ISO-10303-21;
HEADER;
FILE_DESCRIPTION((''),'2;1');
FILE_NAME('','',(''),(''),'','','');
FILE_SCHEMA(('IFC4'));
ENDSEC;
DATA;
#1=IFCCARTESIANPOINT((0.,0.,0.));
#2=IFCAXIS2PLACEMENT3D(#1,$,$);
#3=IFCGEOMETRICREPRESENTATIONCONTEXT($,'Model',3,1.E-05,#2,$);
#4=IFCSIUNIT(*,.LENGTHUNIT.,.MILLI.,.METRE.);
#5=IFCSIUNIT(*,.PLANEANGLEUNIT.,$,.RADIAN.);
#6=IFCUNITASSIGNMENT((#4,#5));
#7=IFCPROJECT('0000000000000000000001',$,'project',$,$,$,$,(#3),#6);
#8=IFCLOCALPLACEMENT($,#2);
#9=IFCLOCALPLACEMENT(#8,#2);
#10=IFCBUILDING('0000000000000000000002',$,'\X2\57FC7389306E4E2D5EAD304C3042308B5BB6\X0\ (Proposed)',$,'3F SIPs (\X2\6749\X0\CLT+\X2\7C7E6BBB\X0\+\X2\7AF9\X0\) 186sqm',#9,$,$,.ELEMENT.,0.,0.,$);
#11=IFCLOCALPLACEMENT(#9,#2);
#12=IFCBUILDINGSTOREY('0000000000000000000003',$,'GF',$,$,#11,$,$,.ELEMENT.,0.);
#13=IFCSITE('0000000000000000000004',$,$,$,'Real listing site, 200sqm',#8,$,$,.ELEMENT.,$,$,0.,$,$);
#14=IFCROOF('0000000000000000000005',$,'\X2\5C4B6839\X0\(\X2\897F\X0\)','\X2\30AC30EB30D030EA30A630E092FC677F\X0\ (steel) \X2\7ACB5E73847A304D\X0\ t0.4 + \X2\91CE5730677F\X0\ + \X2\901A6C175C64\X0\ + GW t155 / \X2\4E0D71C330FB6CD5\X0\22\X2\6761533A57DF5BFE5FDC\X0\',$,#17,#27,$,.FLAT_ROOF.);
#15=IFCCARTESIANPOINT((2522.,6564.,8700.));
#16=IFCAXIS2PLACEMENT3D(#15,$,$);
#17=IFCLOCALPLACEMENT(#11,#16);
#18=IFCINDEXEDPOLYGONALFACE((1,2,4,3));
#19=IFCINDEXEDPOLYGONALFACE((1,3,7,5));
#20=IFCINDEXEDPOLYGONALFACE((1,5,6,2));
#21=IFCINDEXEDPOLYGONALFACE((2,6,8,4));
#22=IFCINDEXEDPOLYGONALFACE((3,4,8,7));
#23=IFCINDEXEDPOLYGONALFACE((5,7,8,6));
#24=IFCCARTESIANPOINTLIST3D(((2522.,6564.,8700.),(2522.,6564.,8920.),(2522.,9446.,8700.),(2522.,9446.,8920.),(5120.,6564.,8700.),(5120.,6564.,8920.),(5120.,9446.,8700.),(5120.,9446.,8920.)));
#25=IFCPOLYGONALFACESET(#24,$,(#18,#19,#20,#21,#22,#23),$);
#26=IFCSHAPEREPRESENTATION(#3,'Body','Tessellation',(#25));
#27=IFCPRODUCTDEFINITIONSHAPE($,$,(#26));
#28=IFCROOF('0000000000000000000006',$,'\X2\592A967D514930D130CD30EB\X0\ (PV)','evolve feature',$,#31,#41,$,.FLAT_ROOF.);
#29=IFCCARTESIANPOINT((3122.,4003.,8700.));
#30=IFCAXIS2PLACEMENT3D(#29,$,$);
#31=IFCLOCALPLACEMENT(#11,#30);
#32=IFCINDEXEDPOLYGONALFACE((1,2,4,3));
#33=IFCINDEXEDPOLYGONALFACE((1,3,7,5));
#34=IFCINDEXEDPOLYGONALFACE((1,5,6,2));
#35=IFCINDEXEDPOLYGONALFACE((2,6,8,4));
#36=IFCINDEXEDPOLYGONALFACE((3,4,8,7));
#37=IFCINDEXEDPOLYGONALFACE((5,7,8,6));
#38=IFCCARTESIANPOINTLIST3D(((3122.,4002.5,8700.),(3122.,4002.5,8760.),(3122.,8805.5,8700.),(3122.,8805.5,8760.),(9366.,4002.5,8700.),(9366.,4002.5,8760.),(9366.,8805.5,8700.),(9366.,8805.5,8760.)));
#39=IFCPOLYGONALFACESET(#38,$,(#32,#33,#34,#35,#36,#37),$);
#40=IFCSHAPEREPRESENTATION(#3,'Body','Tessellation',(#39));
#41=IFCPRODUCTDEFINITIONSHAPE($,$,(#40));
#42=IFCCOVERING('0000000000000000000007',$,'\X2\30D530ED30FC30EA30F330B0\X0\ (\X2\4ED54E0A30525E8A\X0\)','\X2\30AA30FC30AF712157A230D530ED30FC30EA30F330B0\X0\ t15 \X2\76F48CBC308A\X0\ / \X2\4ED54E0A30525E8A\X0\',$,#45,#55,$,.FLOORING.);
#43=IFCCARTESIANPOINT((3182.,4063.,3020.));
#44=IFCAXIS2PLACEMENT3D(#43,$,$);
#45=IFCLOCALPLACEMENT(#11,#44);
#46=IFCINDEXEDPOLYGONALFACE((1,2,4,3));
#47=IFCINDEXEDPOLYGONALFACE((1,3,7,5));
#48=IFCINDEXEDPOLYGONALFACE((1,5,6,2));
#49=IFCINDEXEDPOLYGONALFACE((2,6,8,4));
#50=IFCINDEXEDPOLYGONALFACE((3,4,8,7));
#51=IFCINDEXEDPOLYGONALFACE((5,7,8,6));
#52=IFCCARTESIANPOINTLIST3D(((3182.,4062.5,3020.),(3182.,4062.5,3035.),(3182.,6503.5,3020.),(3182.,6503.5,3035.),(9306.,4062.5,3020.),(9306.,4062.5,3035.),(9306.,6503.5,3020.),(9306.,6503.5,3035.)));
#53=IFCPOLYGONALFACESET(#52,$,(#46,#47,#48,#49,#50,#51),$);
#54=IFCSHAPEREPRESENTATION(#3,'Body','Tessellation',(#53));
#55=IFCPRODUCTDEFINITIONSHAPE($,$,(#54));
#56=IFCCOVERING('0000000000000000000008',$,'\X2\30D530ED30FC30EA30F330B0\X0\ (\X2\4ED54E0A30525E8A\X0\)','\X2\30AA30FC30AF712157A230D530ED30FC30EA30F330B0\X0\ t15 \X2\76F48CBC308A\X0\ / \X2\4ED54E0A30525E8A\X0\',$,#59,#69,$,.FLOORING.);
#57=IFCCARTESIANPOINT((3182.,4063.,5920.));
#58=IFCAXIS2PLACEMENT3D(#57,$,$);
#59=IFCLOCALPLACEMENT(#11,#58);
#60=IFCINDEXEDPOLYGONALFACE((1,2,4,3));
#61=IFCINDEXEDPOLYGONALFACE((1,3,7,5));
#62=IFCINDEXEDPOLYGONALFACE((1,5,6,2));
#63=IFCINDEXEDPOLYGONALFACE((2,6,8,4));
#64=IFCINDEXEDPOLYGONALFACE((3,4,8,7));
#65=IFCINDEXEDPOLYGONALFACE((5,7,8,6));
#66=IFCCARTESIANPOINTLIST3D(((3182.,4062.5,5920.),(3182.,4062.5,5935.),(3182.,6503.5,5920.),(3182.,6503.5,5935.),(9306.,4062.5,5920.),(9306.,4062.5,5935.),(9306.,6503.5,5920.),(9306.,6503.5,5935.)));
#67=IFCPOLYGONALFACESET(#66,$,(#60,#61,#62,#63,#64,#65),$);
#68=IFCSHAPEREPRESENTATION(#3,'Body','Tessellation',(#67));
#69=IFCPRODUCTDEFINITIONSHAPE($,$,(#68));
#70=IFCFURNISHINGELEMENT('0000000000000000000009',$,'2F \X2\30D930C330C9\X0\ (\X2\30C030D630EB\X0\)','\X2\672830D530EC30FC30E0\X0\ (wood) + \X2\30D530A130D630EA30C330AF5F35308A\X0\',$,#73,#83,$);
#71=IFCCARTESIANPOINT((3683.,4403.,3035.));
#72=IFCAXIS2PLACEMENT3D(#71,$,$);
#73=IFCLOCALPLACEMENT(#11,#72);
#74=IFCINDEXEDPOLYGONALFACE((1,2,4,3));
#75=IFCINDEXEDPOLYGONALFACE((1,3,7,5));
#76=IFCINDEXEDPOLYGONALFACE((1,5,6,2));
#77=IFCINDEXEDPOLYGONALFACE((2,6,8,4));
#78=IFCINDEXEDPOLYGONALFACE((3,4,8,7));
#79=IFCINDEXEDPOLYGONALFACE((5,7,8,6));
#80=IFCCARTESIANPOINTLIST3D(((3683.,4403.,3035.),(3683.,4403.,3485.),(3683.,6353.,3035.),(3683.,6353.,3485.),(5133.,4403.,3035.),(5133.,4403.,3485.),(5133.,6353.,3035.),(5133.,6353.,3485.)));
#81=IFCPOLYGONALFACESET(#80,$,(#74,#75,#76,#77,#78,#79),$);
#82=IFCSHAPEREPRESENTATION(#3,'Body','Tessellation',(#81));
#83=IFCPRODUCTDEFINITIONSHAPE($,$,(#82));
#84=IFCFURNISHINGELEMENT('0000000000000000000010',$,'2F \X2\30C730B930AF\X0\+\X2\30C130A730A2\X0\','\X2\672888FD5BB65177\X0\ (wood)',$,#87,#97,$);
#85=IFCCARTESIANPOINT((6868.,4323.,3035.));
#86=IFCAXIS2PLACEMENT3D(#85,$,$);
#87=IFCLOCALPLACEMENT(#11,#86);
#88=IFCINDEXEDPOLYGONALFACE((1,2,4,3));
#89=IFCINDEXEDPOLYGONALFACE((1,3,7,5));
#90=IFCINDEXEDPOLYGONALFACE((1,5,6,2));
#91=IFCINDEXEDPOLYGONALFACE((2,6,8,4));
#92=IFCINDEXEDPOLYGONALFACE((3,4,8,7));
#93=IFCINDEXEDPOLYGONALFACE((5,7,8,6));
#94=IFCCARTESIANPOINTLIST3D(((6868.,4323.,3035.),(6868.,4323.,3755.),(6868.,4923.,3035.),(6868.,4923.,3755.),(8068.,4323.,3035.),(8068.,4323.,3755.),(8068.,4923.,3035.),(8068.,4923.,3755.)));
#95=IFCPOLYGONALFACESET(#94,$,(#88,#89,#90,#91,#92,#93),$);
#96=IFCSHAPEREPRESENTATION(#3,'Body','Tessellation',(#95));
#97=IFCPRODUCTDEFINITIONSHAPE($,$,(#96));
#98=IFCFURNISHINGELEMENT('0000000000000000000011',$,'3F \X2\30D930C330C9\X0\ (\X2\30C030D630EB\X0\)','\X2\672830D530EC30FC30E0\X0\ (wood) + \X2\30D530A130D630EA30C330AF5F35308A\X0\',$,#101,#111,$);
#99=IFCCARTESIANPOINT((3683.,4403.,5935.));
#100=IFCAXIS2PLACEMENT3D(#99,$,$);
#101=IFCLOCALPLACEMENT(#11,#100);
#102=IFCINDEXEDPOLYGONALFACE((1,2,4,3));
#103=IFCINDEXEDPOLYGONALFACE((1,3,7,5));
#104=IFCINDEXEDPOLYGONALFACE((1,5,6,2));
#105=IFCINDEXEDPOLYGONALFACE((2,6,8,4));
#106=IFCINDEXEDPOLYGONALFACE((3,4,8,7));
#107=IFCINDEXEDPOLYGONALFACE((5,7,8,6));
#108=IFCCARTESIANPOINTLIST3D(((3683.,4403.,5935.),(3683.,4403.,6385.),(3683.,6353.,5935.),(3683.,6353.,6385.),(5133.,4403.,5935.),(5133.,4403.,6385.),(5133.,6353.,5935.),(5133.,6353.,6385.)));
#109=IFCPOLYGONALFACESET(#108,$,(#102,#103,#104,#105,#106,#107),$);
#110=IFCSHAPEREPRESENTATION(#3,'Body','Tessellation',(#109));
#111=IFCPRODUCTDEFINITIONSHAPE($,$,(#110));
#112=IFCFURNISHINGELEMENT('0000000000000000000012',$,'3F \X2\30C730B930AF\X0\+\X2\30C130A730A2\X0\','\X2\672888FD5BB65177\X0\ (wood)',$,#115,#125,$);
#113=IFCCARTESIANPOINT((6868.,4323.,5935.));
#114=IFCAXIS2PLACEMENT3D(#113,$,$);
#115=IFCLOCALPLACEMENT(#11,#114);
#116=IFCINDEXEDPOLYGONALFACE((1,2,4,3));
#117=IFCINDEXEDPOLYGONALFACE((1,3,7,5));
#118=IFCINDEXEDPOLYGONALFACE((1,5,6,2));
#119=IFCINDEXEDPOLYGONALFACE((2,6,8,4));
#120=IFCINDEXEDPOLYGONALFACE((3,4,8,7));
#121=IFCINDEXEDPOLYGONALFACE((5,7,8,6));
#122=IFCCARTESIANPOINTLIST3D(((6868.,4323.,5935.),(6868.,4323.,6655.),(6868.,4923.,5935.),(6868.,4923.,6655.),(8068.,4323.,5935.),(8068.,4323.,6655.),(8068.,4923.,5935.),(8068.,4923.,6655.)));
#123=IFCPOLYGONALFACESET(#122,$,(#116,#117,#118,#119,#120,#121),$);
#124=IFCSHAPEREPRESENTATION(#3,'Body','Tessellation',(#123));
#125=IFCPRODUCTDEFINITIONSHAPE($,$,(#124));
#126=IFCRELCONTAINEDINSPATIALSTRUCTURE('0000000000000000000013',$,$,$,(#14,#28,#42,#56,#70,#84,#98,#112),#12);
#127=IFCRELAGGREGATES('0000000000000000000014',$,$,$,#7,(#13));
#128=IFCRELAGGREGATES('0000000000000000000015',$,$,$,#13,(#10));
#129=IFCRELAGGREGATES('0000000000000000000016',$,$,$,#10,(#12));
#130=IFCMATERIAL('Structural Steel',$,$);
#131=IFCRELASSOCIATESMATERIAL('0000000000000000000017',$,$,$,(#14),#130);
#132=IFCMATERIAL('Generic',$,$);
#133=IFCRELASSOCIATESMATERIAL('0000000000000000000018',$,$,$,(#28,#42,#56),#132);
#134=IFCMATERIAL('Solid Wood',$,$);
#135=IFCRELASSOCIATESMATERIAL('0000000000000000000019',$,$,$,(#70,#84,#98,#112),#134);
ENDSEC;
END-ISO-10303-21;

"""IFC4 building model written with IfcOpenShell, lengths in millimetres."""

from ifc_helpers import new_model, si_unit, frame, frame_2d, origin, place, context, project, spatial, rectangle, extrude, material, element, save


model = new_model("IFC4")

# Units and contexts
model_context = context("Model", 3, precision=1e-05, world=origin())
ifc_project = project(units=[si_unit("LENGTHUNIT", "METRE", prefix="MILLI"), si_unit("PLANEANGLEUNIT", "RADIAN")], contexts=[model_context])

# Site, building, storey
site_placement = place(None, origin())
site = spatial("IfcSite", under=ifc_project, at=site_placement, ObjectType="Real listing site, 200sqm", CompositionType="ELEMENT", RefElevation=0.0)
building_placement = place(site_placement, origin())
building = spatial("IfcBuilding", under=site, at=building_placement, Name="埼玉の中庭がある家 (Proposed)", ObjectType="3F SIPs (杉CLT+籾殻+竹) 186sqm", CompositionType="ELEMENT", ElevationOfRefHeight=0.0, ElevationOfTerrain=0.0)
storey_placement = place(building_placement, origin())
storey = spatial("IfcBuildingStorey", under=building, at=storey_placement, Name="GF", CompositionType="ELEMENT", Elevation=0.0)

# Shared definitions
ifc_material_1 = material(Name="Solid Wood")

# Roofs
ifc_material_2 = material(Name="Structural Steel")
roof_1_placement = place(storey_placement, frame((2522.0, 6564.0, 8700.0)))
element("IfcRoof", 1, at=roof_1_placement, inside=storey, material=ifc_material_2, Name="屋根(西)", Description="ガルバリウム鋼板 (steel) 立平葺き t0.4 + 野地板 + 通気層 + GW t155 / 不燃・法22条区域対応", PredefinedType="FLAT_ROOF", context=model_context, shape_type="SweptSolid", body=[
    extrude(rectangle(XDim=2598.0, YDim=2882.0, at=frame_2d((1299.0, 1441.0))), frame((2522.0, 6564.0, 8700.0)), (0.0, 0.0, 1.0), 220.0),
])
ifc_material_3 = material(Name="Generic")
roof_2_placement = place(storey_placement, frame((3122.0, 4003.0, 8700.0)))
element("IfcRoof", 2, at=roof_2_placement, inside=storey, material=ifc_material_3, Name="太陽光パネル (PV)", Description="evolve feature", PredefinedType="FLAT_ROOF", context=model_context, shape_type="SweptSolid", body=[
    extrude(rectangle(XDim=6244.0, YDim=4803.0, at=frame_2d((3122.0, 2401.0))), frame((3122.0, 4003.0, 8700.0)), (0.0, 0.0, 1.0), 60.0),
])

# Coverings
covering_1_placement = place(storey_placement, frame((3182.0, 4063.0, 3020.0)))
element("IfcCovering", 3, at=covering_1_placement, inside=storey, material=ifc_material_3, Name="フローリング (仕上げ床)", Description="オーク無垢フローリング t15 直貼り / 仕上げ床", PredefinedType="FLOORING", context=model_context, shape_type="SweptSolid", body=[
    extrude(rectangle(XDim=6124.0, YDim=2441.0, at=frame_2d((3062.0, 1220.0))), frame((3182.0, 4063.0, 3020.0)), (0.0, 0.0, 1.0), 15.0),
])
covering_2_placement = place(storey_placement, frame((3182.0, 4063.0, 5920.0)))
element("IfcCovering", 4, at=covering_2_placement, inside=storey, material=ifc_material_3, Name="フローリング (仕上げ床)", Description="オーク無垢フローリング t15 直貼り / 仕上げ床", PredefinedType="FLOORING", context=model_context, shape_type="SweptSolid", body=[
    extrude(rectangle(XDim=6124.0, YDim=2441.0, at=frame_2d((3062.0, 1220.0))), frame((3182.0, 4063.0, 5920.0)), (0.0, 0.0, 1.0), 15.0),
])

# Furnishing elements
furnishing_1_placement = place(storey_placement, frame((3683.0, 4403.0, 3035.0)))
element("IfcFurnishingElement", 5, at=furnishing_1_placement, inside=storey, material=ifc_material_1, Name="2F ベッド (ダブル)", Description="木フレーム (wood) + ファブリック張り", context=model_context, shape_type="SweptSolid", body=[
    extrude(rectangle(XDim=1450.0, YDim=1950.0, at=frame_2d((725.0, 975.0))), frame((3683.0, 4403.0, 3035.0)), (0.0, 0.0, 1.0), 450.0),
])
furnishing_2_placement = place(storey_placement, frame((6868.0, 4323.0, 3035.0)))
element("IfcFurnishingElement", 6, at=furnishing_2_placement, inside=storey, material=ifc_material_1, Name="2F デスク+チェア", Description="木製家具 (wood)", context=model_context, shape_type="SweptSolid", body=[
    extrude(rectangle(XDim=1200.0, YDim=600.0, at=frame_2d((600.0, 300.0))), frame((6868.0, 4323.0, 3035.0)), (0.0, 0.0, 1.0), 720.0),
])
furnishing_3_placement = place(storey_placement, frame((3683.0, 4403.0, 5935.0)))
element("IfcFurnishingElement", 7, at=furnishing_3_placement, inside=storey, material=ifc_material_1, Name="3F ベッド (ダブル)", Description="木フレーム (wood) + ファブリック張り", context=model_context, shape_type="SweptSolid", body=[
    extrude(rectangle(XDim=1450.0, YDim=1950.0, at=frame_2d((725.0, 975.0))), frame((3683.0, 4403.0, 5935.0)), (0.0, 0.0, 1.0), 450.0),
])
furnishing_4_placement = place(storey_placement, frame((6868.0, 4323.0, 5935.0)))
element("IfcFurnishingElement", 8, at=furnishing_4_placement, inside=storey, material=ifc_material_1, Name="3F デスク+チェア", Description="木製家具 (wood)", context=model_context, shape_type="SweptSolid", body=[
    extrude(rectangle(XDim=1200.0, YDim=600.0, at=frame_2d((600.0, 300.0))), frame((6868.0, 4323.0, 5935.0)), (0.0, 0.0, 1.0), 720.0),
])

save(model, "model.ifc")
